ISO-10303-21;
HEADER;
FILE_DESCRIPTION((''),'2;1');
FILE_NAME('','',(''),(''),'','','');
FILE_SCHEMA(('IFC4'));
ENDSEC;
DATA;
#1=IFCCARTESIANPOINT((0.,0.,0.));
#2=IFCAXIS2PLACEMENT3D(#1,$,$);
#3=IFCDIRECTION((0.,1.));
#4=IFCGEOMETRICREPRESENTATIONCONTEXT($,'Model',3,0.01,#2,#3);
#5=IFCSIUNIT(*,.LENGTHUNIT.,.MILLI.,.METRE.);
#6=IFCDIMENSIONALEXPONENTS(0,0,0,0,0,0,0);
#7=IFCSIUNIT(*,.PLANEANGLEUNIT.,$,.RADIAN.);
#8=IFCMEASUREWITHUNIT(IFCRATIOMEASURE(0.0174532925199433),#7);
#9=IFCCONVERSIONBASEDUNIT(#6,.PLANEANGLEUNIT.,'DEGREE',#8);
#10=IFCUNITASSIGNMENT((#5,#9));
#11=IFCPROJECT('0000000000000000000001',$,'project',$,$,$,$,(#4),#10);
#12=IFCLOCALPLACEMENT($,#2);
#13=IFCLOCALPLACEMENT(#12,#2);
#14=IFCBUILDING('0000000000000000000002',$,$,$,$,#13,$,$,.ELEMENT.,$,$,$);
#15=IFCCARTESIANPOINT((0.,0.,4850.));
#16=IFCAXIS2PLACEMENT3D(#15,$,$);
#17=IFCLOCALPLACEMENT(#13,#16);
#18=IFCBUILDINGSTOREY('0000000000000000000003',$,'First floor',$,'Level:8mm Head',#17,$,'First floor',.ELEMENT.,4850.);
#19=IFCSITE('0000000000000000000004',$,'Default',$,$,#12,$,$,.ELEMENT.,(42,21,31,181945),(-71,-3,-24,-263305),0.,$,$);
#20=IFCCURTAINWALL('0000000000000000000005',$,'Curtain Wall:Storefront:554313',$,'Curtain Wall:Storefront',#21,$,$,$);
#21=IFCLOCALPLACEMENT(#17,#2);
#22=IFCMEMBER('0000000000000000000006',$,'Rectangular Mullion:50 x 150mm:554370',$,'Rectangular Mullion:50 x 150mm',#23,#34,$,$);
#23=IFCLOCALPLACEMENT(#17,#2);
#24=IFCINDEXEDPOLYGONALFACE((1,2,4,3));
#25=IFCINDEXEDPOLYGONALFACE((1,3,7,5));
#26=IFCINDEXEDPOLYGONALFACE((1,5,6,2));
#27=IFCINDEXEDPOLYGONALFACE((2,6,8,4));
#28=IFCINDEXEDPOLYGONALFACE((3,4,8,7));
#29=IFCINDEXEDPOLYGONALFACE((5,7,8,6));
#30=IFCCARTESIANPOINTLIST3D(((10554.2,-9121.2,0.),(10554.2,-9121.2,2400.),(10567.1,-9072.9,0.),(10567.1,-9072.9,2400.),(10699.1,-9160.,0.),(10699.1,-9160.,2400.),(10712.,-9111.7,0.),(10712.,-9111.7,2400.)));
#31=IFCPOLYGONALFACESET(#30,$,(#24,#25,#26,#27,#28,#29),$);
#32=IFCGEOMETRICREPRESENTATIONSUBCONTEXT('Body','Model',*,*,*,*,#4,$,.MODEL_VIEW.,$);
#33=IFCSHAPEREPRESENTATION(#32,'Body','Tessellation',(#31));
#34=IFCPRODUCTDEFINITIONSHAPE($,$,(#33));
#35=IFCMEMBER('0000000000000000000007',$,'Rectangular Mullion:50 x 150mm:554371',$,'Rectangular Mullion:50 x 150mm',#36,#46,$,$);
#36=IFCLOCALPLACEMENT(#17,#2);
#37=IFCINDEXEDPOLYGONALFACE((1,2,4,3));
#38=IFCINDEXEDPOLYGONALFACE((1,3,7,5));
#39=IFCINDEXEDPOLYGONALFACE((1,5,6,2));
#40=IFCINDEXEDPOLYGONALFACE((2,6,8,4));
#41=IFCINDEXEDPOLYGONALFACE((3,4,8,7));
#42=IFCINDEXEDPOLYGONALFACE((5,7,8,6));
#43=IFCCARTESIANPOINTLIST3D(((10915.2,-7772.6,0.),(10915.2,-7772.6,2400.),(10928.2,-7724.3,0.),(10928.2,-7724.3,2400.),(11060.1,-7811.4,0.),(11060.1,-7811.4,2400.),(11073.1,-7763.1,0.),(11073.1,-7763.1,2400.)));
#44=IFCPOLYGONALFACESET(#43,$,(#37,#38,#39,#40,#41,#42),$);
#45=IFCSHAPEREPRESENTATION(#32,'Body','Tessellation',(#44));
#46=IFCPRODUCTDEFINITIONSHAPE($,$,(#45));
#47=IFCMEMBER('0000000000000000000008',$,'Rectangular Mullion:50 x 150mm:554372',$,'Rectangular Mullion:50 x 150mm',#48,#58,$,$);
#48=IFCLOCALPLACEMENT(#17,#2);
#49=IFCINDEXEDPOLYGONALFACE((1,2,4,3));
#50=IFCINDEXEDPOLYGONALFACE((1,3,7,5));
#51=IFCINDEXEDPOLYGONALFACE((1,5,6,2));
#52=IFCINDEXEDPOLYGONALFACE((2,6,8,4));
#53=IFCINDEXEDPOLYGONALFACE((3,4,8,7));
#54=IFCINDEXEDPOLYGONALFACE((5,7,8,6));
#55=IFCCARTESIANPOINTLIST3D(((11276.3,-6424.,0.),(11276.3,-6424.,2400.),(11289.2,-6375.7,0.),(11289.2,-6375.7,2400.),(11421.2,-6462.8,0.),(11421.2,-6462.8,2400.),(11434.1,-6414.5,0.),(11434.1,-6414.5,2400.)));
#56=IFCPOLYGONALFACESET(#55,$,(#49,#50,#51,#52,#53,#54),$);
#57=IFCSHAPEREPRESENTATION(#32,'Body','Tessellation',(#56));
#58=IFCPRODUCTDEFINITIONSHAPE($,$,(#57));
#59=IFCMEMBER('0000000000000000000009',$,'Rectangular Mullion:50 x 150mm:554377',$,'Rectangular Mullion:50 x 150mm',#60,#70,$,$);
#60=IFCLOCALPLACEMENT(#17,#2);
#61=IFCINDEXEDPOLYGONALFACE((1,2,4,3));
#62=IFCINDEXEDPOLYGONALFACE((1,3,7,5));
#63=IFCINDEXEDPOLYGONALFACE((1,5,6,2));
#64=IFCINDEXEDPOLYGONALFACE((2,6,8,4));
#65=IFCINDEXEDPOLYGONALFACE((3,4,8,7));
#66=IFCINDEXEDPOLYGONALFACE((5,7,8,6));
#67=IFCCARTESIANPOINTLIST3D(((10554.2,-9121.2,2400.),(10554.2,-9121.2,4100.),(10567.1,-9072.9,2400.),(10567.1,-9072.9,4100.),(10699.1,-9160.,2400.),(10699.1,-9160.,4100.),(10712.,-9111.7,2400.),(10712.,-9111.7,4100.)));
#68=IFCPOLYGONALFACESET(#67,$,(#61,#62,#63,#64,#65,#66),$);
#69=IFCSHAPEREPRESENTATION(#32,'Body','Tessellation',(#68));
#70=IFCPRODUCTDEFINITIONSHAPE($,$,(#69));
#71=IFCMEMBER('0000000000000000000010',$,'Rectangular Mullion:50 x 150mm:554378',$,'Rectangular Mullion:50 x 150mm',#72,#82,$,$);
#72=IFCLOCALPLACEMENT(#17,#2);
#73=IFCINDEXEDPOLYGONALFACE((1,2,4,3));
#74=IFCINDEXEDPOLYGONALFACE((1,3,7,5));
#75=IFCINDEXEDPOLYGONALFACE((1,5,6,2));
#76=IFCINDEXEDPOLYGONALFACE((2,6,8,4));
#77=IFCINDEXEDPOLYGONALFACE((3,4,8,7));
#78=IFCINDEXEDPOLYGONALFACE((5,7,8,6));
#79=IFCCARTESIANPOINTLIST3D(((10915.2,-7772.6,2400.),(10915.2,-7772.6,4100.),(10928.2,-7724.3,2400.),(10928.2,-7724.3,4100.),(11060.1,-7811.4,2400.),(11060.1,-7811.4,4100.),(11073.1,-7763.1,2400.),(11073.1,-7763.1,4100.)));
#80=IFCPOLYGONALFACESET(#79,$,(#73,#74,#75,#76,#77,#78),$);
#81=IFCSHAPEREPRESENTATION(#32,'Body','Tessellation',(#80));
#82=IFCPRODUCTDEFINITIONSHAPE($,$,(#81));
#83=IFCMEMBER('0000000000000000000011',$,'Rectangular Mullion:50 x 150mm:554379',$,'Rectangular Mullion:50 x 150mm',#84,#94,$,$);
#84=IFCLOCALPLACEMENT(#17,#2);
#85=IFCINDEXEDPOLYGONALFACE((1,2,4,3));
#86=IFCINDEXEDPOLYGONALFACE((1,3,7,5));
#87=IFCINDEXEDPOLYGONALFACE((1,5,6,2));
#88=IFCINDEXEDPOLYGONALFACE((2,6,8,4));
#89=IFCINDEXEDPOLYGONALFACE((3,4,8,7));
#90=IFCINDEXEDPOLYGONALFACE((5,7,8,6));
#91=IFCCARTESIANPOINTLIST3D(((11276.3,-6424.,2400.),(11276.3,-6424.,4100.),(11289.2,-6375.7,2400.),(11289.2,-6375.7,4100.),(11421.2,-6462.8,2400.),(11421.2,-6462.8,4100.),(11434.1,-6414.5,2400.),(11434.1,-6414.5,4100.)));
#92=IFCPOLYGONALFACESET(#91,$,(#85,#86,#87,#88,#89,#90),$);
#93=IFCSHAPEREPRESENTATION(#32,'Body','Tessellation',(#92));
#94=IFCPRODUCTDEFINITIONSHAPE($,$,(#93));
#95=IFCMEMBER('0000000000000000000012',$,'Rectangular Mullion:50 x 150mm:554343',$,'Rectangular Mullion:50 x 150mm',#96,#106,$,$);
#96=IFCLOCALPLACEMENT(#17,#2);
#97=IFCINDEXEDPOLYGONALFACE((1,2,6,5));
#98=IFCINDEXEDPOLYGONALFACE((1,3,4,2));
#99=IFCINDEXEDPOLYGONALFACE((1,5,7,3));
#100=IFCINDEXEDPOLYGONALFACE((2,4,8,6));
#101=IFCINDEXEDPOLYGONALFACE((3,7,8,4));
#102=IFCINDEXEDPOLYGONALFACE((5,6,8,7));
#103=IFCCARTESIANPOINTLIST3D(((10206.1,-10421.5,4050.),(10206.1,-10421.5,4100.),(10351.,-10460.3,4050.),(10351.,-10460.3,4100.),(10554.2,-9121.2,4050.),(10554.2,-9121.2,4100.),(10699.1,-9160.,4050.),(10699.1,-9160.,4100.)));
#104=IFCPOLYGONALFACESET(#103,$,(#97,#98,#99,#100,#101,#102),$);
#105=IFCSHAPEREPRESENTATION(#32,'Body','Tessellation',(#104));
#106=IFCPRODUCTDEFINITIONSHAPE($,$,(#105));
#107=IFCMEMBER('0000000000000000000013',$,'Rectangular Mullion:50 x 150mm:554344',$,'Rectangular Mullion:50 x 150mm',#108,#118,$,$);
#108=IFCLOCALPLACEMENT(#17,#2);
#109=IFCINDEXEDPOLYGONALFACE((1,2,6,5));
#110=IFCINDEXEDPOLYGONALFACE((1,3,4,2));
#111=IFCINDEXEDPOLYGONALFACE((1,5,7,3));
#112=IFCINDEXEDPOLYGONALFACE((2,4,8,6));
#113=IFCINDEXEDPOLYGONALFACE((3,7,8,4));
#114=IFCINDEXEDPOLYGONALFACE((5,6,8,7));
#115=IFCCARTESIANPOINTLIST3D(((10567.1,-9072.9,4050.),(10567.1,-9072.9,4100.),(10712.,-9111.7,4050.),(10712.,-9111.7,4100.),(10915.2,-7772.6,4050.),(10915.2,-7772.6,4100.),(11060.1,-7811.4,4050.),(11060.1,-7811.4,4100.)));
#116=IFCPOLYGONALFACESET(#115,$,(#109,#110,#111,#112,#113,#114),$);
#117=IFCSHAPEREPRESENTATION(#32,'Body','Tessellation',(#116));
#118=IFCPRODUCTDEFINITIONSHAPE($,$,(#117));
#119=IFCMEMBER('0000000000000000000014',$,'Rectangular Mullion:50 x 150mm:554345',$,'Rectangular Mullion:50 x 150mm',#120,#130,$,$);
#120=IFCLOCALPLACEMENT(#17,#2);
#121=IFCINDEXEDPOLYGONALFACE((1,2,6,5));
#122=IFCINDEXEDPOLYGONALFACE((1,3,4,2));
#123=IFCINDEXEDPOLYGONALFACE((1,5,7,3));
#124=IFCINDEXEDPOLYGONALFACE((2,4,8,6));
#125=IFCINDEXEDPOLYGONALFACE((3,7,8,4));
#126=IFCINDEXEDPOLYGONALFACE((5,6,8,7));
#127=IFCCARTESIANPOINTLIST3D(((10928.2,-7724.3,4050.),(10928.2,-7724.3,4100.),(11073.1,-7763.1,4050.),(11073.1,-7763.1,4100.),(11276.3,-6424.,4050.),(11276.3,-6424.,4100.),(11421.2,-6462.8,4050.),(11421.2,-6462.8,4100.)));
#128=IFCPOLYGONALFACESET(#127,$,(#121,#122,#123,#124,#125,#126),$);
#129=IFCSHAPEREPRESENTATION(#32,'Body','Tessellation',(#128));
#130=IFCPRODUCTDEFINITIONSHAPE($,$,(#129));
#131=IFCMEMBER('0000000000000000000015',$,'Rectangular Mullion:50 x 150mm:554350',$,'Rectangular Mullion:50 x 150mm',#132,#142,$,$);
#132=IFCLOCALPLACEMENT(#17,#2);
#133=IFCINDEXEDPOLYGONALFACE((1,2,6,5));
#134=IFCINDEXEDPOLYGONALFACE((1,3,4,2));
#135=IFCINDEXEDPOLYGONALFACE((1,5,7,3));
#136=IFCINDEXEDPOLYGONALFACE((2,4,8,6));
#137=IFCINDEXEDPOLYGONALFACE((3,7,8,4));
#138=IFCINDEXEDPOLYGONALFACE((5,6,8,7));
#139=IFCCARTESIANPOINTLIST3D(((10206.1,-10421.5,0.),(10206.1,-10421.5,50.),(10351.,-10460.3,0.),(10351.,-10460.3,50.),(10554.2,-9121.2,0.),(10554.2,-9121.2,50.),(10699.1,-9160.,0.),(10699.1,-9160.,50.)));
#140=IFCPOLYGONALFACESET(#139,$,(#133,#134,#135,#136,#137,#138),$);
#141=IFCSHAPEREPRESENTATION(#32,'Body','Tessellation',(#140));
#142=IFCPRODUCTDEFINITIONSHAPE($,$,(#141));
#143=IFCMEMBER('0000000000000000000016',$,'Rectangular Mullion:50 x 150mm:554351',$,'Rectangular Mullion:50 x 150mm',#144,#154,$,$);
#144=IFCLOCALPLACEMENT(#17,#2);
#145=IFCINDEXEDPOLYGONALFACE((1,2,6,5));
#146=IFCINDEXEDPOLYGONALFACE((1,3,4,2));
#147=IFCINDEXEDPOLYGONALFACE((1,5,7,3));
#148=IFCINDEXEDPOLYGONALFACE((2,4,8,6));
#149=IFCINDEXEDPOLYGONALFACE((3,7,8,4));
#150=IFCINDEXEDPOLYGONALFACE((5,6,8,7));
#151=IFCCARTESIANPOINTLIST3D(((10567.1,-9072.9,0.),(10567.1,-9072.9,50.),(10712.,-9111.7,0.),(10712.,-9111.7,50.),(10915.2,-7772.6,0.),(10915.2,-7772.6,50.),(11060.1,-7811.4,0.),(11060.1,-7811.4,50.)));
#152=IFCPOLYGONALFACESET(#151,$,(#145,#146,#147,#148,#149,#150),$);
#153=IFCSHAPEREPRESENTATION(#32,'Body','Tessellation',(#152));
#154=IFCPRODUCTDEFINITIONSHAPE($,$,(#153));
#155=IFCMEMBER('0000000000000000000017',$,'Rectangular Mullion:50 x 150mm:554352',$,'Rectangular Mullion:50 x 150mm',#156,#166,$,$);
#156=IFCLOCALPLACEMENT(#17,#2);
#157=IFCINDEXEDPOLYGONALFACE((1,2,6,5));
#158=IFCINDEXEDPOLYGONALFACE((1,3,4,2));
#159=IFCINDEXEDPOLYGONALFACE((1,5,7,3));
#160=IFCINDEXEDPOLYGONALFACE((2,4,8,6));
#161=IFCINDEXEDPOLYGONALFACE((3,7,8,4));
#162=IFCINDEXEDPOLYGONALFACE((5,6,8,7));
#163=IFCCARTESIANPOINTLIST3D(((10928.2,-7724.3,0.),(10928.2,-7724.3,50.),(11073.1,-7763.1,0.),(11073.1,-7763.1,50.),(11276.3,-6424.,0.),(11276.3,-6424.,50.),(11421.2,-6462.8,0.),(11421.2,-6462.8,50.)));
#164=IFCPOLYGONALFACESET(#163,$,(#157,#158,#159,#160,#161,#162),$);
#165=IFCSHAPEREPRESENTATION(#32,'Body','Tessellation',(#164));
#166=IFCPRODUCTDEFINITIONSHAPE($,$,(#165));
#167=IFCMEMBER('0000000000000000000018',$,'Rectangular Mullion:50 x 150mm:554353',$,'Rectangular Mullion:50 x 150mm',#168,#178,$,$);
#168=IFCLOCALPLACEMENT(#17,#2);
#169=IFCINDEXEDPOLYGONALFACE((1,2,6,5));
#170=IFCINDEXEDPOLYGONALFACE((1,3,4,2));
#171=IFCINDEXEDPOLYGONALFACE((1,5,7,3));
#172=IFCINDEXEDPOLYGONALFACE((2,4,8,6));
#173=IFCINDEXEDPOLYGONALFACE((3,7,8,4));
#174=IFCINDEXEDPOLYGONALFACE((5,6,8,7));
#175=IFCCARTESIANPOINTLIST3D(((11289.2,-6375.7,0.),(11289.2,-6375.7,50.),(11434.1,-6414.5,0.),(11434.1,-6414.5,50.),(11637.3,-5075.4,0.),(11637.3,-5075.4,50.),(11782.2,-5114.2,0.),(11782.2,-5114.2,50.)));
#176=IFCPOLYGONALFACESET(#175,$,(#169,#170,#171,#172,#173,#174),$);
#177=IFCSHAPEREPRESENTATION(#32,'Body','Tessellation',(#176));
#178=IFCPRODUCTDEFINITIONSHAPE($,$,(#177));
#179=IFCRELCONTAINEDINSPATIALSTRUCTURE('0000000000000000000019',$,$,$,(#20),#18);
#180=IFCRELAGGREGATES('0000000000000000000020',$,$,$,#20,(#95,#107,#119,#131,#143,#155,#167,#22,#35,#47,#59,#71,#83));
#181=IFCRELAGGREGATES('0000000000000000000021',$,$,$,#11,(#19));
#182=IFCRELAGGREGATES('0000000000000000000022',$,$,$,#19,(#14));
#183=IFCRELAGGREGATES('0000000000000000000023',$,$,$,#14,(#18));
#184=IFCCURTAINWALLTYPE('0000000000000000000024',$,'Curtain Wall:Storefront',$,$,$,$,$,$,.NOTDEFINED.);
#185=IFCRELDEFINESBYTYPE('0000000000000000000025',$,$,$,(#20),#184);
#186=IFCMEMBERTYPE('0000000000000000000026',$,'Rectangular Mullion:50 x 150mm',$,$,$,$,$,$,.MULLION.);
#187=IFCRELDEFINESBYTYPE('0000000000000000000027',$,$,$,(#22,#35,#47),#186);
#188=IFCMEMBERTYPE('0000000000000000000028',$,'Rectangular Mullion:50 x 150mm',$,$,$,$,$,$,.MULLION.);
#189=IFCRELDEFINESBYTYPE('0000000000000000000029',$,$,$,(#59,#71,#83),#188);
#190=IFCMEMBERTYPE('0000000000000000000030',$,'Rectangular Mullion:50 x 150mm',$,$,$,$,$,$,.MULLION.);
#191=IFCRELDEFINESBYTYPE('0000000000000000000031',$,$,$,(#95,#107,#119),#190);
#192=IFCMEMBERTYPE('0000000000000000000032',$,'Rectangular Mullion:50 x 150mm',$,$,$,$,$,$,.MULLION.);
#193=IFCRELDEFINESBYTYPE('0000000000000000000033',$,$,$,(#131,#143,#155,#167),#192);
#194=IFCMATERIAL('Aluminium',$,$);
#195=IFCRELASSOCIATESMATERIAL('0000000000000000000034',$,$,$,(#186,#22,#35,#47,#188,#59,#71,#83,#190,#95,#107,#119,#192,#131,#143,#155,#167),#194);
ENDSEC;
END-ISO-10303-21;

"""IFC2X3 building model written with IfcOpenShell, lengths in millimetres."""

from ifc_helpers import new_model, entity, si_unit, converted_unit, direction, frame, origin, origin_2d_with_axis, place, context, subcontext, project, spatial, rectangle, extrude, source, transform, mapped, material, type_object, type_shapes, element, aggregate, save


model = new_model("IFC2X3")

# Units and contexts
model_context = context("Model", 3, precision=0.01, world=origin(), true_north=direction((0.0, 1.0)))
body_context = subcontext(model_context, "Body", "Model", "MODEL_VIEW")
ifc_project = project(units=[si_unit("LENGTHUNIT", "METRE", prefix="MILLI"), converted_unit("PLANEANGLEUNIT", "DEGREE", entity("IfcRatioMeasure", 0.0174532925199433), si_unit("PLANEANGLEUNIT", "RADIAN"), dimensions=[0, 0, 0, 0, 0, 0, 0])], contexts=[model_context])

# Site, building, storey
site_placement = place(None, origin())
site = spatial("IfcSite", under=ifc_project, at=site_placement, Name="Default", CompositionType="ELEMENT", RefLatitude=(42, 21, 31, 181945), RefLongitude=(-71, -3, -24, -263305), RefElevation=0.0)
building_placement = place(site_placement, origin())
building = spatial("IfcBuilding", under=site, at=building_placement, CompositionType="ELEMENT")
storey_placement = place(building_placement, frame((0.0, 0.0, 4850.0)))
storey = spatial("IfcBuildingStorey", under=building, at=storey_placement, Name="First floor", ObjectType="Level:8mm Head", LongName="First floor", CompositionType="ELEMENT", Elevation=4850.0)

# Curtain wall, members
curtain_wall_type = type_object("IfcCurtainWallType", Name="Curtain Wall:Storefront", PredefinedType="NOTDEFINED")
curtain_wall_placement = place(storey_placement, frame((0.0, 0.0, -4850.0)))
curtain_wall = element("IfcCurtainWall", 1, at=curtain_wall_placement, inside=storey, type_object=curtain_wall_type, Name="Curtain Wall:Storefront:554313", ObjectType="Curtain Wall:Storefront")
ifc_material_1 = material(Name="Aluminium")
member_type_1 = type_object("IfcMemberType", Name="Rectangular Mullion:50 x 150mm", PredefinedType="MULLION", material=ifc_material_1)
shared_shape_1 = source(origin(), body_context, "Body", "SweptSolid", [
    extrude(rectangle(XDim=150.0, YDim=50.0, at=origin_2d_with_axis()), frame((0.0, 0.0, -2400.0), z_axis=(0.0, 0.0, 1.0), x_axis=(0.0, -1.0, 0.0)), (0.0, 0.0, 1.0), 2400.0),
])
type_shapes(member_type_1, [shared_shape_1])
member_1_placement = place(storey_placement, frame((10633.1, -9116.5, 0.0), z_axis=(0.0, 0.0, -1.0), x_axis=(0.258607, 0.965983, 0.0)))
member_1 = element("IfcMember", 2, at=member_1_placement, type_object=member_type_1, material=ifc_material_1, Name="Rectangular Mullion:50 x 150mm:554370", ObjectType="Rectangular Mullion:50 x 150mm", context=body_context, shape_type="MappedRepresentation", body=[
    mapped(shared_shape_1, transform((0.0, 0.0, 0.0), scale=1.0)),
])
member_2_placement = place(storey_placement, frame((10994.2, -7767.9, 0.0), z_axis=(0.0, 0.0, -1.0), x_axis=(0.258607, 0.965983, 0.0)))
member_2 = element("IfcMember", 3, at=member_2_placement, type_object=member_type_1, material=ifc_material_1, Name="Rectangular Mullion:50 x 150mm:554371", ObjectType="Rectangular Mullion:50 x 150mm", context=body_context, shape_type="MappedRepresentation", body=[
    mapped(shared_shape_1, transform((0.0, 0.0, 0.0), scale=1.0)),
])
member_3_placement = place(storey_placement, frame((11355.2, -6419.2, 0.0), z_axis=(0.0, 0.0, -1.0), x_axis=(0.258607, 0.965983, 0.0)))
member_3 = element("IfcMember", 4, at=member_3_placement, type_object=member_type_1, material=ifc_material_1, Name="Rectangular Mullion:50 x 150mm:554372", ObjectType="Rectangular Mullion:50 x 150mm", context=body_context, shape_type="MappedRepresentation", body=[
    mapped(shared_shape_1, transform((0.0, 0.0, 0.0), scale=1.0)),
])
member_type_2 = type_object("IfcMemberType", Name="Rectangular Mullion:50 x 150mm", PredefinedType="MULLION", material=ifc_material_1)
shared_shape_2 = source(origin(), body_context, "Body", "SweptSolid", [
    extrude(rectangle(XDim=150.0, YDim=50.0, at=origin_2d_with_axis()), frame((0.0, 0.0, -1700.0), z_axis=(0.0, 0.0, 1.0), x_axis=(0.0, -1.0, 0.0)), (0.0, 0.0, 1.0), 1700.0),
])
type_shapes(member_type_2, [shared_shape_2])
member_4_placement = place(storey_placement, frame((10633.1, -9116.5, 2400.0), z_axis=(0.0, 0.0, -1.0), x_axis=(0.258607, 0.965983, 0.0)))
member_4 = element("IfcMember", 5, at=member_4_placement, type_object=member_type_2, material=ifc_material_1, Name="Rectangular Mullion:50 x 150mm:554377", ObjectType="Rectangular Mullion:50 x 150mm", context=body_context, shape_type="MappedRepresentation", body=[
    mapped(shared_shape_2, transform((0.0, 0.0, 0.0), scale=1.0)),
])
member_5_placement = place(storey_placement, frame((10994.2, -7767.9, 2400.0), z_axis=(0.0, 0.0, -1.0), x_axis=(0.258607, 0.965983, 0.0)))
member_5 = element("IfcMember", 6, at=member_5_placement, type_object=member_type_2, material=ifc_material_1, Name="Rectangular Mullion:50 x 150mm:554378", ObjectType="Rectangular Mullion:50 x 150mm", context=body_context, shape_type="MappedRepresentation", body=[
    mapped(shared_shape_2, transform((0.0, 0.0, 0.0), scale=1.0)),
])
member_6_placement = place(storey_placement, frame((11355.2, -6419.2, 2400.0), z_axis=(0.0, 0.0, -1.0), x_axis=(0.258607, 0.965983, 0.0)))
member_6 = element("IfcMember", 7, at=member_6_placement, type_object=member_type_2, material=ifc_material_1, Name="Rectangular Mullion:50 x 150mm:554379", ObjectType="Rectangular Mullion:50 x 150mm", context=body_context, shape_type="MappedRepresentation", body=[
    mapped(shared_shape_2, transform((0.0, 0.0, 0.0), scale=1.0)),
])
member_type_3 = type_object("IfcMemberType", Name="Rectangular Mullion:50 x 150mm", PredefinedType="MULLION", material=ifc_material_1)
shared_shape_3 = source(origin(), body_context, "Body", "SweptSolid", [
    extrude(rectangle(XDim=150.0, YDim=50.0, at=origin_2d_with_axis()), frame((-25.0, 0.0, -1346.1), z_axis=(0.0, 0.0, 1.0), x_axis=(0.0, -1.0, 0.0)), (0.0, 0.0, 1.0), 1346.1),
])
type_shapes(member_type_3, [shared_shape_3])
member_7_placement = place(storey_placement, frame((10626.7, -9140.6, 4100.0), z_axis=(0.258607, 0.965983, 0.0), x_axis=(0.0, 0.0, 1.0)))
member_7 = element("IfcMember", 8, at=member_7_placement, type_object=member_type_3, material=ifc_material_1, Name="Rectangular Mullion:50 x 150mm:554343", ObjectType="Rectangular Mullion:50 x 150mm", context=body_context, shape_type="MappedRepresentation", body=[
    mapped(shared_shape_3, transform((0.0, 0.0, 0.0), scale=1.0)),
])
member_8_placement = place(storey_placement, frame((10987.7, -7792.0, 4100.0), z_axis=(0.258607, 0.965983, 0.0), x_axis=(0.0, 0.0, 1.0)))
member_8 = element("IfcMember", 9, at=member_8_placement, type_object=member_type_3, material=ifc_material_1, Name="Rectangular Mullion:50 x 150mm:554344", ObjectType="Rectangular Mullion:50 x 150mm", context=body_context, shape_type="MappedRepresentation", body=[
    mapped(shared_shape_3, transform((0.0, 0.0, 0.0), scale=1.0)),
])
member_9_placement = place(storey_placement, frame((11348.7, -6443.4, 4100.0), z_axis=(0.258607, 0.965983, 0.0), x_axis=(0.0, 0.0, 1.0)))
member_9 = element("IfcMember", 10, at=member_9_placement, type_object=member_type_3, material=ifc_material_1, Name="Rectangular Mullion:50 x 150mm:554345", ObjectType="Rectangular Mullion:50 x 150mm", context=body_context, shape_type="MappedRepresentation", body=[
    mapped(shared_shape_3, transform((0.0, 0.0, 0.0), scale=1.0)),
])
member_type_4 = type_object("IfcMemberType", Name="Rectangular Mullion:50 x 150mm", PredefinedType="MULLION", material=ifc_material_1)
shared_shape_4 = source(origin(), body_context, "Body", "SweptSolid", [
    extrude(rectangle(XDim=150.0, YDim=50.0, at=origin_2d_with_axis()), frame((-25.0, 0.0, -1346.1), z_axis=(0.0, 0.0, 1.0), x_axis=(0.0, -1.0, 0.0)), (0.0, 0.0, 1.0), 1346.1),
])
type_shapes(member_type_4, [shared_shape_4])
member_10_placement = place(storey_placement, frame((10278.5, -10440.9, 0.0), z_axis=(-0.258607, -0.965983, 0.0), x_axis=(0.0, 0.0, -1.0)))
member_10 = element("IfcMember", 11, at=member_10_placement, type_object=member_type_4, material=ifc_material_1, Name="Rectangular Mullion:50 x 150mm:554350", ObjectType="Rectangular Mullion:50 x 150mm", context=body_context, shape_type="MappedRepresentation", body=[
    mapped(shared_shape_4, transform((0.0, 0.0, 0.0), scale=1.0)),
])
member_11_placement = place(storey_placement, frame((10639.6, -9092.3, 0.0), z_axis=(-0.258607, -0.965983, 0.0), x_axis=(0.0, 0.0, -1.0)))
member_11 = element("IfcMember", 12, at=member_11_placement, type_object=member_type_4, material=ifc_material_1, Name="Rectangular Mullion:50 x 150mm:554351", ObjectType="Rectangular Mullion:50 x 150mm", context=body_context, shape_type="MappedRepresentation", body=[
    mapped(shared_shape_4, transform((0.0, 0.0, 0.0), scale=1.0)),
])
member_12_placement = place(storey_placement, frame((11000.6, -7743.7, 0.0), z_axis=(-0.258607, -0.965983, 0.0), x_axis=(0.0, 0.0, -1.0)))
member_12 = element("IfcMember", 13, at=member_12_placement, type_object=member_type_4, material=ifc_material_1, Name="Rectangular Mullion:50 x 150mm:554352", ObjectType="Rectangular Mullion:50 x 150mm", context=body_context, shape_type="MappedRepresentation", body=[
    mapped(shared_shape_4, transform((0.0, 0.0, 0.0), scale=1.0)),
])
member_13_placement = place(storey_placement, frame((11361.7, -6395.1, 0.0), z_axis=(-0.258607, -0.965983, 0.0), x_axis=(0.0, 0.0, -1.0)))
member_13 = element("IfcMember", 14, at=member_13_placement, type_object=member_type_4, material=ifc_material_1, Name="Rectangular Mullion:50 x 150mm:554353", ObjectType="Rectangular Mullion:50 x 150mm", context=body_context, shape_type="MappedRepresentation", body=[
    mapped(shared_shape_4, transform((0.0, 0.0, 0.0), scale=1.0)),
])
aggregate(curtain_wall, [member_7, member_8, member_9, member_10, member_11, member_12, member_13, member_1, member_2, member_3, member_4, member_5, member_6])

save(model, "model.ifc")
